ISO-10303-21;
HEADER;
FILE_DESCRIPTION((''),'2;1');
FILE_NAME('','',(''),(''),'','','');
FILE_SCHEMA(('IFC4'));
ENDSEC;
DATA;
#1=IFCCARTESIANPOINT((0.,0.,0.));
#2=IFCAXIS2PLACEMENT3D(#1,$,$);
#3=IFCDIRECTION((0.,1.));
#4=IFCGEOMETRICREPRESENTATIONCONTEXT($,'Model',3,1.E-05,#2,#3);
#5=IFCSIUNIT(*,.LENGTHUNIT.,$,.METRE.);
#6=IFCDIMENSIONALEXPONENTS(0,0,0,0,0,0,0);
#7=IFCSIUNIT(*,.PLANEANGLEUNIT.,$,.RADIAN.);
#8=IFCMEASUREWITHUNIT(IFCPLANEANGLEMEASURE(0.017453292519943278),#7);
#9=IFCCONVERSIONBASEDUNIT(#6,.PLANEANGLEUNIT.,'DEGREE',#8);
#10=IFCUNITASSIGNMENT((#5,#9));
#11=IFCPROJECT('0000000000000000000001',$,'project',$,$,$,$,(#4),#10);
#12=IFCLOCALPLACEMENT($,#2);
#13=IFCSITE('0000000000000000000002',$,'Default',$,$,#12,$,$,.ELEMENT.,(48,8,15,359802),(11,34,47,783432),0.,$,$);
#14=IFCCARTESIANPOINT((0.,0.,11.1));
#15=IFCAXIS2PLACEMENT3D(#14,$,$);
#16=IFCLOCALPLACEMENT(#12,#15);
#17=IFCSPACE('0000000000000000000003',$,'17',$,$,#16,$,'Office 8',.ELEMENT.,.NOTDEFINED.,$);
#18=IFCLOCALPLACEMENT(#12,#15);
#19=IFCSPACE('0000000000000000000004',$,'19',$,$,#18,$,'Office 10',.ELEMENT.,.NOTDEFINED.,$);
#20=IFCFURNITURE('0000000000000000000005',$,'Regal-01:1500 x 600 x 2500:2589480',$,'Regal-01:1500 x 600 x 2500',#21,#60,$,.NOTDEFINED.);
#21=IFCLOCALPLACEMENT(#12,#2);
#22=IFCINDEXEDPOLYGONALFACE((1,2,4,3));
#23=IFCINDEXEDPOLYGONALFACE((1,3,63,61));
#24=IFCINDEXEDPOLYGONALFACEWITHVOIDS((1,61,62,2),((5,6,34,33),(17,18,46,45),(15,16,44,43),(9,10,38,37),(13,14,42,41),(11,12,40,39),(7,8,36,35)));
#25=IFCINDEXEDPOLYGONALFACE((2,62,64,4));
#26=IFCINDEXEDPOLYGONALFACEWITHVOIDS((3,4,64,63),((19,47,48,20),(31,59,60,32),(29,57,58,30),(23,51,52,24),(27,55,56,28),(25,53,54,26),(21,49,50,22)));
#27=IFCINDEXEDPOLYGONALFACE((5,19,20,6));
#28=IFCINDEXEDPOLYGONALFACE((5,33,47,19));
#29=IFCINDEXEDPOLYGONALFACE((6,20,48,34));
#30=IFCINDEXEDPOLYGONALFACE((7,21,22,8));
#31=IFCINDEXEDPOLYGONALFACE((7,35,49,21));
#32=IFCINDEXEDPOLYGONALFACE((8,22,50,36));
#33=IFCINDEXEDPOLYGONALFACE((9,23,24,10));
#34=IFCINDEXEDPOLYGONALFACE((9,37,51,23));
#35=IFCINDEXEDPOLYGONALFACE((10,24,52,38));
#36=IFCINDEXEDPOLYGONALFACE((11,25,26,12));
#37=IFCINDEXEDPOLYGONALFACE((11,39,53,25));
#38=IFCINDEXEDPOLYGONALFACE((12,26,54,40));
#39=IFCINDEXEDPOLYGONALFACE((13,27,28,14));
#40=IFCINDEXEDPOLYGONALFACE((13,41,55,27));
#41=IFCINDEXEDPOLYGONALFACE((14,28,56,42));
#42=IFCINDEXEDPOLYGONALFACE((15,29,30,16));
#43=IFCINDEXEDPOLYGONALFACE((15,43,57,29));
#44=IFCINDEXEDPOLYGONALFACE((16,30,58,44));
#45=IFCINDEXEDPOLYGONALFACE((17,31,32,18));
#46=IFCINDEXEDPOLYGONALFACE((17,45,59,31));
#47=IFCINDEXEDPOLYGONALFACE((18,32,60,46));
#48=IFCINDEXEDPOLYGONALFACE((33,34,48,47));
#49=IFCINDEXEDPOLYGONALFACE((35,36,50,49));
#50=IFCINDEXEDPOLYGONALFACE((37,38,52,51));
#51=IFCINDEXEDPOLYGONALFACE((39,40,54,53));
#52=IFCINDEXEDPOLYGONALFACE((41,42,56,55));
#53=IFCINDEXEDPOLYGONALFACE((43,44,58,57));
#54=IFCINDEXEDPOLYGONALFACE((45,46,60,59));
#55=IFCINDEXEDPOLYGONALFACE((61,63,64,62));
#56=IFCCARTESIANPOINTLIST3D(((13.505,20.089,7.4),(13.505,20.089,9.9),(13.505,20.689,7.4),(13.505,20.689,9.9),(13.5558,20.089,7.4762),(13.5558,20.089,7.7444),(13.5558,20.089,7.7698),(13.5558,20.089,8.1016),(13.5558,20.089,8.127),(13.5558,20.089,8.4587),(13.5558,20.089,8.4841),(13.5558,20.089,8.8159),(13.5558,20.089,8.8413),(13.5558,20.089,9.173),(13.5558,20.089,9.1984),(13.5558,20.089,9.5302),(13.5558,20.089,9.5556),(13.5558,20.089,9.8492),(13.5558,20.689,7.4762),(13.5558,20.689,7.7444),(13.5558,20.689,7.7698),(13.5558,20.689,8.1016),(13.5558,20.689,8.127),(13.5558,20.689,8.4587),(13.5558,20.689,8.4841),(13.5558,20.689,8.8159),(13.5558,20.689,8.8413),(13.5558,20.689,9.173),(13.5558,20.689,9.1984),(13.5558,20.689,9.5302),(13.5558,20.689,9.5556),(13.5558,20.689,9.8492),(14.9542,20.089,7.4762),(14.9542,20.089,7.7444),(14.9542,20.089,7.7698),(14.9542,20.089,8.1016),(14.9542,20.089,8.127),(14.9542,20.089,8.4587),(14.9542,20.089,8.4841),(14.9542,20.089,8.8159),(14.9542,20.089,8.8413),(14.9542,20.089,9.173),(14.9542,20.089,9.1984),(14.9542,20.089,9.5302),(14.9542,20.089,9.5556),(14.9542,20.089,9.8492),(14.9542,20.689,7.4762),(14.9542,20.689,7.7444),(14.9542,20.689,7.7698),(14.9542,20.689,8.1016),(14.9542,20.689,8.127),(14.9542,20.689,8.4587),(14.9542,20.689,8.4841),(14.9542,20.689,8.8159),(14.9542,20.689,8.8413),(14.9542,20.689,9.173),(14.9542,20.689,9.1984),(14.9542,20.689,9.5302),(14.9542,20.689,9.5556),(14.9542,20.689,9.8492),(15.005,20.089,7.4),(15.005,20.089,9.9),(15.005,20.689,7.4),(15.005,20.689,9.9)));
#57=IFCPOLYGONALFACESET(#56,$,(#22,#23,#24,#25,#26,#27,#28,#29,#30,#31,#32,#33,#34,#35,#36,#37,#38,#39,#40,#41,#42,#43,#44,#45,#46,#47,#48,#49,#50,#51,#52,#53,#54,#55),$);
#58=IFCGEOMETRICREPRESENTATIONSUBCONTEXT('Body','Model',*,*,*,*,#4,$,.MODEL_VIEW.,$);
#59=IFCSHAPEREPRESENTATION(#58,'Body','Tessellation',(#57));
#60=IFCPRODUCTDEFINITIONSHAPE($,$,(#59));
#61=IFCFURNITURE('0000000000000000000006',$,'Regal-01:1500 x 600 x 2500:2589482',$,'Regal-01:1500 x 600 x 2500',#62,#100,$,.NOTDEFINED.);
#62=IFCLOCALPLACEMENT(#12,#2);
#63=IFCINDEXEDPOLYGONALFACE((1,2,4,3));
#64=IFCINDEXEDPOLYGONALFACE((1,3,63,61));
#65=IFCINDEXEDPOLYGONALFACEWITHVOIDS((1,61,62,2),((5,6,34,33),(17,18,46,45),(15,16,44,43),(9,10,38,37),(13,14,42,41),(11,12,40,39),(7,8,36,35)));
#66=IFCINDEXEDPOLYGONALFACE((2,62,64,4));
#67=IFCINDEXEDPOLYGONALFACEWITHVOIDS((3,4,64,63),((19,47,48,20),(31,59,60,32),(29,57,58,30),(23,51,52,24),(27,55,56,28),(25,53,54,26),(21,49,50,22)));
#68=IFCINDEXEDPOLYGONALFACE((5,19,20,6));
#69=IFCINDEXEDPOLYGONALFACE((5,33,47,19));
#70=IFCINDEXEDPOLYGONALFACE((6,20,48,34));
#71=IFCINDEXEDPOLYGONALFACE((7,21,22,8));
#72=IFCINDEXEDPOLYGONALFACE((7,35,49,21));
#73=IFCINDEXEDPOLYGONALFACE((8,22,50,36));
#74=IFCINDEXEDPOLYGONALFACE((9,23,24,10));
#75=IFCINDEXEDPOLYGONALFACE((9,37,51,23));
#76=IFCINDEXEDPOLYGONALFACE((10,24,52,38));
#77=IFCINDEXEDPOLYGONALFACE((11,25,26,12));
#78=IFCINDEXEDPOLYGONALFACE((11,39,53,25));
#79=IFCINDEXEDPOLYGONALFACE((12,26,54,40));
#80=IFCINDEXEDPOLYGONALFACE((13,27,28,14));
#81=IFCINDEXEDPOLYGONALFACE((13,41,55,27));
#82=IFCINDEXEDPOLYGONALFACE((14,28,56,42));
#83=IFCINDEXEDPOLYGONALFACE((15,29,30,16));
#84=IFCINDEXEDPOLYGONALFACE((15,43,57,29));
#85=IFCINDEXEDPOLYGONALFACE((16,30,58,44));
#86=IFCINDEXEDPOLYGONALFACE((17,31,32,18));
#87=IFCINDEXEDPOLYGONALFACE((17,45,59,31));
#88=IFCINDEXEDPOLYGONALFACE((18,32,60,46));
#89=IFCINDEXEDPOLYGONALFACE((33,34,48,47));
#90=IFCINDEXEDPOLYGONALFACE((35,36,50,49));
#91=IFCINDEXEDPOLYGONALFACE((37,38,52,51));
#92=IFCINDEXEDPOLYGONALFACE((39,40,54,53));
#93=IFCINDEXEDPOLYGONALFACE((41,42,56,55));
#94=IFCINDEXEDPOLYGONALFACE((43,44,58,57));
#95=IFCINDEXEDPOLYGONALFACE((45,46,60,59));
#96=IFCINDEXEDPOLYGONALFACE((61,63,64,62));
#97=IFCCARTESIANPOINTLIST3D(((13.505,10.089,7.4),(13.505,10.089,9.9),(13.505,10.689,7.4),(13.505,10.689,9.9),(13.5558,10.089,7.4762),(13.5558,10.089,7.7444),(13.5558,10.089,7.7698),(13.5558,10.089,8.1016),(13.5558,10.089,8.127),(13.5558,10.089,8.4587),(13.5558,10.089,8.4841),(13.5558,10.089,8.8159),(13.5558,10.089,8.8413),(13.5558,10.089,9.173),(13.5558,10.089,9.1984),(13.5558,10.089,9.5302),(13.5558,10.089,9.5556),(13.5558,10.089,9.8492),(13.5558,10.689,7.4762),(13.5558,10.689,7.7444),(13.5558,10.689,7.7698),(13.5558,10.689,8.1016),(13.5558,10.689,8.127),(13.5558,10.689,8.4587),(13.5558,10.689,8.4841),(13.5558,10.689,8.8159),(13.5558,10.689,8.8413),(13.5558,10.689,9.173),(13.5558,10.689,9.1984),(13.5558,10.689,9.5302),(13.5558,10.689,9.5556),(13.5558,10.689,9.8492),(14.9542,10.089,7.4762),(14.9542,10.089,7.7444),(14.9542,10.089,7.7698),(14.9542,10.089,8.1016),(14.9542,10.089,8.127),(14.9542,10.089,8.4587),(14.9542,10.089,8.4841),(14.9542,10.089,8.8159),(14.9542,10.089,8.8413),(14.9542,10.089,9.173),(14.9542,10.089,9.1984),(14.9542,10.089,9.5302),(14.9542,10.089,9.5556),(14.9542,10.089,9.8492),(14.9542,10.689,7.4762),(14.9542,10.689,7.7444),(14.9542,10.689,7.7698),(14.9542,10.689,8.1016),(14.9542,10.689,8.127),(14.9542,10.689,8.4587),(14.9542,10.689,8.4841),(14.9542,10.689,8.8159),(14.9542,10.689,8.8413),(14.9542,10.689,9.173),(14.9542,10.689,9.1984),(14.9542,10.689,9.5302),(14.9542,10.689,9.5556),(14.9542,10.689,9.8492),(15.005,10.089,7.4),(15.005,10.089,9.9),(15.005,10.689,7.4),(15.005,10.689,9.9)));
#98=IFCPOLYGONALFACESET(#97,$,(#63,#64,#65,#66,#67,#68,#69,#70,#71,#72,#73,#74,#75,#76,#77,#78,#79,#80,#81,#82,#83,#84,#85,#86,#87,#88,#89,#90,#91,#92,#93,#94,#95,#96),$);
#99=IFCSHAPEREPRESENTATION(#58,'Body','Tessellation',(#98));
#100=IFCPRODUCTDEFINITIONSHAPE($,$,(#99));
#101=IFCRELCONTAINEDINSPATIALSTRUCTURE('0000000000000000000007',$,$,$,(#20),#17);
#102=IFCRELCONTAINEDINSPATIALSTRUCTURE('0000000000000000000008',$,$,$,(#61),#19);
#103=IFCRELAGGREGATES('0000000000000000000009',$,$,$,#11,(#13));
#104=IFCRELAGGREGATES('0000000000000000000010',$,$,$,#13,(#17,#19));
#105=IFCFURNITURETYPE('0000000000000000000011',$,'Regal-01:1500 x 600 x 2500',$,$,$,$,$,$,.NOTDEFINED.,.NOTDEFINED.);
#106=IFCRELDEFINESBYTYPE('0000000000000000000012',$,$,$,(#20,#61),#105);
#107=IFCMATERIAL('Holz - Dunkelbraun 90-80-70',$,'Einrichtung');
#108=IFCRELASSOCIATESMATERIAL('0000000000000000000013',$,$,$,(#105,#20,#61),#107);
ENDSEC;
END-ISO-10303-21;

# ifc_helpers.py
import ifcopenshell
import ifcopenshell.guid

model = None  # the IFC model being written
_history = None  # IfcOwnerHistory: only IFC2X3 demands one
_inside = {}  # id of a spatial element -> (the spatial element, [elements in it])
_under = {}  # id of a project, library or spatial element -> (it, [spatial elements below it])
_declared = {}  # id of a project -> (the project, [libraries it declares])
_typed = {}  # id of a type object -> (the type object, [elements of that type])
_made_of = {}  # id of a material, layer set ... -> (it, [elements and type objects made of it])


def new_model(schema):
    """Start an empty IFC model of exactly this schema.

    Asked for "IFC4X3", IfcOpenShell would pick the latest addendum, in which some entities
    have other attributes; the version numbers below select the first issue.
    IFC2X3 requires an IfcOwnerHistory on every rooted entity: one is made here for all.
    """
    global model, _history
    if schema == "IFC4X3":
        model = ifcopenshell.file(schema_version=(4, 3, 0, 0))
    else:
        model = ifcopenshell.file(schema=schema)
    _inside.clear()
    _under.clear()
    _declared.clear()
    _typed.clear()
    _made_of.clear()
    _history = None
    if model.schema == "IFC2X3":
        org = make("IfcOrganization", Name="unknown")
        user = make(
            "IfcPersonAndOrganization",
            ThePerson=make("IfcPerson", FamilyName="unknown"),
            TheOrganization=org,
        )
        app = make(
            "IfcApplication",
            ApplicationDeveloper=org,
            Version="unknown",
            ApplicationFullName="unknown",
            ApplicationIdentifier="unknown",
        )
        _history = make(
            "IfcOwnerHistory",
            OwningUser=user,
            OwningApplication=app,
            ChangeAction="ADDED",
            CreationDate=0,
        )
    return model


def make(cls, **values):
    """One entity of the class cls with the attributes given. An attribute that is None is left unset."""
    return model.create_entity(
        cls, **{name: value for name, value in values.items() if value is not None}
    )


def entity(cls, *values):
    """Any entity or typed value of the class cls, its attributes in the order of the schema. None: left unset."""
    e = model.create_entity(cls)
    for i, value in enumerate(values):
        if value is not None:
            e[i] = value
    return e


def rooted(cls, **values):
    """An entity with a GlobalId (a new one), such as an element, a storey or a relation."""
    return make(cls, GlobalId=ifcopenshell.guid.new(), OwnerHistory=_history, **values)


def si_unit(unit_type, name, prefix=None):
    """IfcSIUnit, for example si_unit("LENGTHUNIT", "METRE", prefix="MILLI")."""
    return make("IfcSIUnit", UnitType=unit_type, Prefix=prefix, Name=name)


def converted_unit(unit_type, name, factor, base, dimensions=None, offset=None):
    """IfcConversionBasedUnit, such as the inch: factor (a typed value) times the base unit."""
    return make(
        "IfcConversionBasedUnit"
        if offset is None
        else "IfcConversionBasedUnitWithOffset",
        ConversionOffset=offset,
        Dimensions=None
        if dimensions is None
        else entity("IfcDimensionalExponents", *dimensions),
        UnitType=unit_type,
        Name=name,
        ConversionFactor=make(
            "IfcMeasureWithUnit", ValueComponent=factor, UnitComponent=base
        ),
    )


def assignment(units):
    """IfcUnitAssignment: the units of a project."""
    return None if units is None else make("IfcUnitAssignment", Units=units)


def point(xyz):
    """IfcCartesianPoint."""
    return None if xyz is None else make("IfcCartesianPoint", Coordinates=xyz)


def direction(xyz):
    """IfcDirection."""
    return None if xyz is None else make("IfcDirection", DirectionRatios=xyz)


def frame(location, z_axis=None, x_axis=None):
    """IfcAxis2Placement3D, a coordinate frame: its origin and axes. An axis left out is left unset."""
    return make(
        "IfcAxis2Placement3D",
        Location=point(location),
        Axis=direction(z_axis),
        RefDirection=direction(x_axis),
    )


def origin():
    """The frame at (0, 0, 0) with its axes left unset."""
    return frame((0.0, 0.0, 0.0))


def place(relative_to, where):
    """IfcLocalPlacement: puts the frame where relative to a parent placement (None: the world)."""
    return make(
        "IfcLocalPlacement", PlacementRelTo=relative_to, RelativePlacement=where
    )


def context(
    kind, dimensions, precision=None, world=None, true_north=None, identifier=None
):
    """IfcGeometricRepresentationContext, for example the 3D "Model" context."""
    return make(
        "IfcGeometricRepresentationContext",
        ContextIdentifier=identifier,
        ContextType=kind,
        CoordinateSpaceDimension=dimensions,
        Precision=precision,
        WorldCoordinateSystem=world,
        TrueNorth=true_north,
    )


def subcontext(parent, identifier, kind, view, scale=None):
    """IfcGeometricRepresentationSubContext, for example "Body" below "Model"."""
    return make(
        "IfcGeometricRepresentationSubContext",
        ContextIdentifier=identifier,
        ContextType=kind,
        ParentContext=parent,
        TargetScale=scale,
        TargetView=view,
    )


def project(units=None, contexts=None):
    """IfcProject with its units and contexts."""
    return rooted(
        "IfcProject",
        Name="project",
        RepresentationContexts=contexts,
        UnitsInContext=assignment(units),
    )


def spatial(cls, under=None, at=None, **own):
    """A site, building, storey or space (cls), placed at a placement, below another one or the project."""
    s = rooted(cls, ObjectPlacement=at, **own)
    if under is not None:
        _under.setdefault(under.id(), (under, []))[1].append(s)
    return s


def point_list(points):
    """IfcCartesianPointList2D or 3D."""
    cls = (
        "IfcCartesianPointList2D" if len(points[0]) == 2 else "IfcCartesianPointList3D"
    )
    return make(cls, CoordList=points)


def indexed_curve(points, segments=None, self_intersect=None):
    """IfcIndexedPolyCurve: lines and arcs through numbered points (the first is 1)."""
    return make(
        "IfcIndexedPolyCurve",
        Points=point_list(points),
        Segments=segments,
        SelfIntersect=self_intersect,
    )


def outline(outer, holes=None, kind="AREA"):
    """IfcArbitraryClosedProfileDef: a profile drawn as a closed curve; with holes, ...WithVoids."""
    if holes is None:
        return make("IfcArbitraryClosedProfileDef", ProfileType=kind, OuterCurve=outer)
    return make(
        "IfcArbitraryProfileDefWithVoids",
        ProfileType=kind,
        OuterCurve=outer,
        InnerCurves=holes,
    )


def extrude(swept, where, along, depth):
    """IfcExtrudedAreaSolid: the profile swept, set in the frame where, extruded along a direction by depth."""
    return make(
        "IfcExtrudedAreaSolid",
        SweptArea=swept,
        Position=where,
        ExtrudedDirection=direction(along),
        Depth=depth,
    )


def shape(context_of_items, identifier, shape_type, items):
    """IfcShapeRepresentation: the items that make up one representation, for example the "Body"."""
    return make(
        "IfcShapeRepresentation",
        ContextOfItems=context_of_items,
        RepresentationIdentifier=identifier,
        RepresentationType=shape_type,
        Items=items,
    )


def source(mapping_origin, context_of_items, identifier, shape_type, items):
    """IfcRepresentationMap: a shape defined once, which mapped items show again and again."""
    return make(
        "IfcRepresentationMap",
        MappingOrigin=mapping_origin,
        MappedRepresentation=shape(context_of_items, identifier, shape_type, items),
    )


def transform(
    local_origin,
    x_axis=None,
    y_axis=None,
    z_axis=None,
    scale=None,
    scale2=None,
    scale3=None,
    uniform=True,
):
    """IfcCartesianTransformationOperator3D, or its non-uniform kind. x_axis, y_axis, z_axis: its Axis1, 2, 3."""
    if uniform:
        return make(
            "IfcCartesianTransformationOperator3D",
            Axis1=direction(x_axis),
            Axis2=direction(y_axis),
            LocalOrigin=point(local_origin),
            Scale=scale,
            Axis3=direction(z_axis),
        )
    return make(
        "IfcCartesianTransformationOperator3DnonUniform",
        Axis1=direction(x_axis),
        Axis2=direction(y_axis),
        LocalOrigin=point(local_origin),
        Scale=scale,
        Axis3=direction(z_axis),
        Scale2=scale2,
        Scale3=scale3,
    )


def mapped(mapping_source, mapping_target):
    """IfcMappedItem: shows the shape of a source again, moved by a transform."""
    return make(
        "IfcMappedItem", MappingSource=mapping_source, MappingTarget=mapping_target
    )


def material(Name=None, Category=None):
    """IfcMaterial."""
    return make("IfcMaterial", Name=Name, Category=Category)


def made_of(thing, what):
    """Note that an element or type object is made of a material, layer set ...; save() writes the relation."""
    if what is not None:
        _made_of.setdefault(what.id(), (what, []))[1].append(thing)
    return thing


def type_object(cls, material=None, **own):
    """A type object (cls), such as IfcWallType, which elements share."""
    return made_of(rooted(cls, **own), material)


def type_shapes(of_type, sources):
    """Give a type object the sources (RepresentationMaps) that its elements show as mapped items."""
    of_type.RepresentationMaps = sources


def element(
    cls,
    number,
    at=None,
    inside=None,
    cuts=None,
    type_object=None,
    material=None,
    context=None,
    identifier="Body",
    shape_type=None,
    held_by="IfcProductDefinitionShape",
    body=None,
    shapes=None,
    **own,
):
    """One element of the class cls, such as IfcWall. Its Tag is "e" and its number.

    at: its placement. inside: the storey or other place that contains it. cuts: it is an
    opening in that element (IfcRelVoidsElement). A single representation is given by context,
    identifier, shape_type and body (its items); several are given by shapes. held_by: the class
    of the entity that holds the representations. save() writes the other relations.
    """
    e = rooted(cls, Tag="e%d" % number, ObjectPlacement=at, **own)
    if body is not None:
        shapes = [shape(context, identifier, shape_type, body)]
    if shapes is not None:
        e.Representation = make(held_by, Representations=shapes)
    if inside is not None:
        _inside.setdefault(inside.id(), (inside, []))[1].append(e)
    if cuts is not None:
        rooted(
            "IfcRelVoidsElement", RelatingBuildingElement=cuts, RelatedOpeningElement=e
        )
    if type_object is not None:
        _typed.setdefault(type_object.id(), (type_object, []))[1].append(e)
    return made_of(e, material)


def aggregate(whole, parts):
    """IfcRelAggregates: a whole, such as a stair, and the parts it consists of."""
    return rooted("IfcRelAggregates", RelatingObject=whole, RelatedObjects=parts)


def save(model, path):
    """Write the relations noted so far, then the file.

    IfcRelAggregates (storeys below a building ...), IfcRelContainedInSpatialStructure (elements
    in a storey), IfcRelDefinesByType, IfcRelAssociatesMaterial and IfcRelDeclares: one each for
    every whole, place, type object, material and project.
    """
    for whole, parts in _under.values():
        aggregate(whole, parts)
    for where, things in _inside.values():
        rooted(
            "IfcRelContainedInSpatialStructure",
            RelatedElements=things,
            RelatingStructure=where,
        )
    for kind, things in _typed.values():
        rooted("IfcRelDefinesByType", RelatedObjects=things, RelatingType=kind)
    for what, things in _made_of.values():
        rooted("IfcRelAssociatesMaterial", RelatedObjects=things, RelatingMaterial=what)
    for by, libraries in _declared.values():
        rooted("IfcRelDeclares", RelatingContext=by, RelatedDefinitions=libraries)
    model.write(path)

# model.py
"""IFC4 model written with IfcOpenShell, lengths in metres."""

from ifc_helpers import new_model, entity, si_unit, converted_unit, direction, frame, origin, place, context, subcontext, project, spatial, indexed_curve, outline, extrude, source, transform, mapped, material, type_object, type_shapes, element, save


model = new_model("IFC4")

# Units and contexts
model_context = context("Model", 3, precision=1e-05, world=origin(), true_north=direction((0.0, 1.0)))
body_context = subcontext(model_context, "Body", "Model", "MODEL_VIEW")
ifc_project = project(units=[si_unit("LENGTHUNIT", "METRE"), converted_unit("PLANEANGLEUNIT", "DEGREE", entity("IfcPlaneAngleMeasure", 0.017453292519943278), si_unit("PLANEANGLEUNIT", "RADIAN"), dimensions=[0, 0, 0, 0, 0, 0, 0])], contexts=[model_context])

# Site
site_placement = place(None, origin())
site = spatial("IfcSite", under=ifc_project, at=site_placement, Name="Default", CompositionType="ELEMENT", RefLatitude=(48, 8, 15, 359802), RefLongitude=(11, 34, 47, 783432), RefElevation=0.0)

# Shared definitions
ifc_material = material(Name="Holz - Dunkelbraun 90-80-70", Category="Einrichtung")
furniture_type = type_object("IfcFurnitureType", Name="Regal-01:1500 x 600 x 2500", AssemblyPlace="NOTDEFINED", PredefinedType="NOTDEFINED", material=ifc_material)
shared_shape = source(origin(), body_context, "Body", "SweptSolid", [
    extrude(outline(indexed_curve([(-0.75, -1.25), (0.75, -1.25), (0.75, 1.25), (-0.75, 1.25), (-0.75, -1.25)], self_intersect=False), holes=[indexed_curve([(-0.6992, 1.1992), (0.6992, 1.1992), (0.6992, 0.9056), (-0.6992, 0.9056), (-0.6992, 1.1992)], self_intersect=False), indexed_curve([(-0.6992, -1.1738), (-0.6992, -0.9056), (0.6992, -0.9056), (0.6992, -1.1738), (-0.6992, -1.1738)], self_intersect=False), indexed_curve([(0.6992, 0.1913), (-0.6992, 0.1913), (-0.6992, 0.523), (0.6992, 0.523), (0.6992, 0.1913)], self_intersect=False), indexed_curve([(0.6992, -0.5484), (0.6992, -0.8802), (-0.6992, -0.8802), (-0.6992, -0.5484), (0.6992, -0.5484)], self_intersect=False), indexed_curve([(-0.6992, 0.8802), (0.6992, 0.8802), (0.6992, 0.5484), (-0.6992, 0.5484), (-0.6992, 0.8802)], self_intersect=False), indexed_curve([(-0.6992, 0.1659), (0.6992, 0.1659), (0.6992, -0.1659), (-0.6992, -0.1659), (-0.6992, 0.1659)], self_intersect=False), indexed_curve([(-0.6992, -0.1913), (0.6992, -0.1913), (0.6992, -0.523), (-0.6992, -0.523), (-0.6992, -0.1913)], self_intersect=False)]), frame((0.0, -0.6048, 1.25), z_axis=(0.0, 1.0, 0.0), x_axis=(-1.0, 0.0, 0.0)), (0.0, 0.0, 1.0), 0.6),
])
type_shapes(furniture_type, [shared_shape])

# Shared definitions
space_1_placement = place(site_placement, frame((0.0, 0.0, 11.1)))
space_1 = spatial("IfcSpace", under=site, at=space_1_placement, Name="17", LongName="Office 8", CompositionType="ELEMENT", PredefinedType="NOTDEFINED")

# Furniture
furniture_1_placement = place(space_1_placement, frame((14.255, 20.6938, -3.7)))
element("IfcFurniture", 1, at=furniture_1_placement, inside=space_1, type_object=furniture_type, material=ifc_material, Name="Regal-01:1500 x 600 x 2500:2589480", ObjectType="Regal-01:1500 x 600 x 2500", PredefinedType="NOTDEFINED", context=body_context, shape_type="MappedRepresentation", body=[
    mapped(shared_shape, transform((0.0, 0.0, 0.0), scale=1.0)),
])

# Shared definitions
space_2_placement = place(site_placement, frame((0.0, 0.0, 11.1)))
space_2 = spatial("IfcSpace", under=site, at=space_2_placement, Name="19", LongName="Office 10", CompositionType="ELEMENT", PredefinedType="NOTDEFINED")

# Furniture
furniture_2_placement = place(space_2_placement, frame((14.255, 10.6938, -3.7)))
element("IfcFurniture", 2, at=furniture_2_placement, inside=space_2, type_object=furniture_type, material=ifc_material, Name="Regal-01:1500 x 600 x 2500:2589482", ObjectType="Regal-01:1500 x 600 x 2500", PredefinedType="NOTDEFINED", context=body_context, shape_type="MappedRepresentation", body=[
    mapped(shared_shape, transform((0.0, 0.0, 0.0), scale=1.0)),
])

save(model, "model.ifc")
